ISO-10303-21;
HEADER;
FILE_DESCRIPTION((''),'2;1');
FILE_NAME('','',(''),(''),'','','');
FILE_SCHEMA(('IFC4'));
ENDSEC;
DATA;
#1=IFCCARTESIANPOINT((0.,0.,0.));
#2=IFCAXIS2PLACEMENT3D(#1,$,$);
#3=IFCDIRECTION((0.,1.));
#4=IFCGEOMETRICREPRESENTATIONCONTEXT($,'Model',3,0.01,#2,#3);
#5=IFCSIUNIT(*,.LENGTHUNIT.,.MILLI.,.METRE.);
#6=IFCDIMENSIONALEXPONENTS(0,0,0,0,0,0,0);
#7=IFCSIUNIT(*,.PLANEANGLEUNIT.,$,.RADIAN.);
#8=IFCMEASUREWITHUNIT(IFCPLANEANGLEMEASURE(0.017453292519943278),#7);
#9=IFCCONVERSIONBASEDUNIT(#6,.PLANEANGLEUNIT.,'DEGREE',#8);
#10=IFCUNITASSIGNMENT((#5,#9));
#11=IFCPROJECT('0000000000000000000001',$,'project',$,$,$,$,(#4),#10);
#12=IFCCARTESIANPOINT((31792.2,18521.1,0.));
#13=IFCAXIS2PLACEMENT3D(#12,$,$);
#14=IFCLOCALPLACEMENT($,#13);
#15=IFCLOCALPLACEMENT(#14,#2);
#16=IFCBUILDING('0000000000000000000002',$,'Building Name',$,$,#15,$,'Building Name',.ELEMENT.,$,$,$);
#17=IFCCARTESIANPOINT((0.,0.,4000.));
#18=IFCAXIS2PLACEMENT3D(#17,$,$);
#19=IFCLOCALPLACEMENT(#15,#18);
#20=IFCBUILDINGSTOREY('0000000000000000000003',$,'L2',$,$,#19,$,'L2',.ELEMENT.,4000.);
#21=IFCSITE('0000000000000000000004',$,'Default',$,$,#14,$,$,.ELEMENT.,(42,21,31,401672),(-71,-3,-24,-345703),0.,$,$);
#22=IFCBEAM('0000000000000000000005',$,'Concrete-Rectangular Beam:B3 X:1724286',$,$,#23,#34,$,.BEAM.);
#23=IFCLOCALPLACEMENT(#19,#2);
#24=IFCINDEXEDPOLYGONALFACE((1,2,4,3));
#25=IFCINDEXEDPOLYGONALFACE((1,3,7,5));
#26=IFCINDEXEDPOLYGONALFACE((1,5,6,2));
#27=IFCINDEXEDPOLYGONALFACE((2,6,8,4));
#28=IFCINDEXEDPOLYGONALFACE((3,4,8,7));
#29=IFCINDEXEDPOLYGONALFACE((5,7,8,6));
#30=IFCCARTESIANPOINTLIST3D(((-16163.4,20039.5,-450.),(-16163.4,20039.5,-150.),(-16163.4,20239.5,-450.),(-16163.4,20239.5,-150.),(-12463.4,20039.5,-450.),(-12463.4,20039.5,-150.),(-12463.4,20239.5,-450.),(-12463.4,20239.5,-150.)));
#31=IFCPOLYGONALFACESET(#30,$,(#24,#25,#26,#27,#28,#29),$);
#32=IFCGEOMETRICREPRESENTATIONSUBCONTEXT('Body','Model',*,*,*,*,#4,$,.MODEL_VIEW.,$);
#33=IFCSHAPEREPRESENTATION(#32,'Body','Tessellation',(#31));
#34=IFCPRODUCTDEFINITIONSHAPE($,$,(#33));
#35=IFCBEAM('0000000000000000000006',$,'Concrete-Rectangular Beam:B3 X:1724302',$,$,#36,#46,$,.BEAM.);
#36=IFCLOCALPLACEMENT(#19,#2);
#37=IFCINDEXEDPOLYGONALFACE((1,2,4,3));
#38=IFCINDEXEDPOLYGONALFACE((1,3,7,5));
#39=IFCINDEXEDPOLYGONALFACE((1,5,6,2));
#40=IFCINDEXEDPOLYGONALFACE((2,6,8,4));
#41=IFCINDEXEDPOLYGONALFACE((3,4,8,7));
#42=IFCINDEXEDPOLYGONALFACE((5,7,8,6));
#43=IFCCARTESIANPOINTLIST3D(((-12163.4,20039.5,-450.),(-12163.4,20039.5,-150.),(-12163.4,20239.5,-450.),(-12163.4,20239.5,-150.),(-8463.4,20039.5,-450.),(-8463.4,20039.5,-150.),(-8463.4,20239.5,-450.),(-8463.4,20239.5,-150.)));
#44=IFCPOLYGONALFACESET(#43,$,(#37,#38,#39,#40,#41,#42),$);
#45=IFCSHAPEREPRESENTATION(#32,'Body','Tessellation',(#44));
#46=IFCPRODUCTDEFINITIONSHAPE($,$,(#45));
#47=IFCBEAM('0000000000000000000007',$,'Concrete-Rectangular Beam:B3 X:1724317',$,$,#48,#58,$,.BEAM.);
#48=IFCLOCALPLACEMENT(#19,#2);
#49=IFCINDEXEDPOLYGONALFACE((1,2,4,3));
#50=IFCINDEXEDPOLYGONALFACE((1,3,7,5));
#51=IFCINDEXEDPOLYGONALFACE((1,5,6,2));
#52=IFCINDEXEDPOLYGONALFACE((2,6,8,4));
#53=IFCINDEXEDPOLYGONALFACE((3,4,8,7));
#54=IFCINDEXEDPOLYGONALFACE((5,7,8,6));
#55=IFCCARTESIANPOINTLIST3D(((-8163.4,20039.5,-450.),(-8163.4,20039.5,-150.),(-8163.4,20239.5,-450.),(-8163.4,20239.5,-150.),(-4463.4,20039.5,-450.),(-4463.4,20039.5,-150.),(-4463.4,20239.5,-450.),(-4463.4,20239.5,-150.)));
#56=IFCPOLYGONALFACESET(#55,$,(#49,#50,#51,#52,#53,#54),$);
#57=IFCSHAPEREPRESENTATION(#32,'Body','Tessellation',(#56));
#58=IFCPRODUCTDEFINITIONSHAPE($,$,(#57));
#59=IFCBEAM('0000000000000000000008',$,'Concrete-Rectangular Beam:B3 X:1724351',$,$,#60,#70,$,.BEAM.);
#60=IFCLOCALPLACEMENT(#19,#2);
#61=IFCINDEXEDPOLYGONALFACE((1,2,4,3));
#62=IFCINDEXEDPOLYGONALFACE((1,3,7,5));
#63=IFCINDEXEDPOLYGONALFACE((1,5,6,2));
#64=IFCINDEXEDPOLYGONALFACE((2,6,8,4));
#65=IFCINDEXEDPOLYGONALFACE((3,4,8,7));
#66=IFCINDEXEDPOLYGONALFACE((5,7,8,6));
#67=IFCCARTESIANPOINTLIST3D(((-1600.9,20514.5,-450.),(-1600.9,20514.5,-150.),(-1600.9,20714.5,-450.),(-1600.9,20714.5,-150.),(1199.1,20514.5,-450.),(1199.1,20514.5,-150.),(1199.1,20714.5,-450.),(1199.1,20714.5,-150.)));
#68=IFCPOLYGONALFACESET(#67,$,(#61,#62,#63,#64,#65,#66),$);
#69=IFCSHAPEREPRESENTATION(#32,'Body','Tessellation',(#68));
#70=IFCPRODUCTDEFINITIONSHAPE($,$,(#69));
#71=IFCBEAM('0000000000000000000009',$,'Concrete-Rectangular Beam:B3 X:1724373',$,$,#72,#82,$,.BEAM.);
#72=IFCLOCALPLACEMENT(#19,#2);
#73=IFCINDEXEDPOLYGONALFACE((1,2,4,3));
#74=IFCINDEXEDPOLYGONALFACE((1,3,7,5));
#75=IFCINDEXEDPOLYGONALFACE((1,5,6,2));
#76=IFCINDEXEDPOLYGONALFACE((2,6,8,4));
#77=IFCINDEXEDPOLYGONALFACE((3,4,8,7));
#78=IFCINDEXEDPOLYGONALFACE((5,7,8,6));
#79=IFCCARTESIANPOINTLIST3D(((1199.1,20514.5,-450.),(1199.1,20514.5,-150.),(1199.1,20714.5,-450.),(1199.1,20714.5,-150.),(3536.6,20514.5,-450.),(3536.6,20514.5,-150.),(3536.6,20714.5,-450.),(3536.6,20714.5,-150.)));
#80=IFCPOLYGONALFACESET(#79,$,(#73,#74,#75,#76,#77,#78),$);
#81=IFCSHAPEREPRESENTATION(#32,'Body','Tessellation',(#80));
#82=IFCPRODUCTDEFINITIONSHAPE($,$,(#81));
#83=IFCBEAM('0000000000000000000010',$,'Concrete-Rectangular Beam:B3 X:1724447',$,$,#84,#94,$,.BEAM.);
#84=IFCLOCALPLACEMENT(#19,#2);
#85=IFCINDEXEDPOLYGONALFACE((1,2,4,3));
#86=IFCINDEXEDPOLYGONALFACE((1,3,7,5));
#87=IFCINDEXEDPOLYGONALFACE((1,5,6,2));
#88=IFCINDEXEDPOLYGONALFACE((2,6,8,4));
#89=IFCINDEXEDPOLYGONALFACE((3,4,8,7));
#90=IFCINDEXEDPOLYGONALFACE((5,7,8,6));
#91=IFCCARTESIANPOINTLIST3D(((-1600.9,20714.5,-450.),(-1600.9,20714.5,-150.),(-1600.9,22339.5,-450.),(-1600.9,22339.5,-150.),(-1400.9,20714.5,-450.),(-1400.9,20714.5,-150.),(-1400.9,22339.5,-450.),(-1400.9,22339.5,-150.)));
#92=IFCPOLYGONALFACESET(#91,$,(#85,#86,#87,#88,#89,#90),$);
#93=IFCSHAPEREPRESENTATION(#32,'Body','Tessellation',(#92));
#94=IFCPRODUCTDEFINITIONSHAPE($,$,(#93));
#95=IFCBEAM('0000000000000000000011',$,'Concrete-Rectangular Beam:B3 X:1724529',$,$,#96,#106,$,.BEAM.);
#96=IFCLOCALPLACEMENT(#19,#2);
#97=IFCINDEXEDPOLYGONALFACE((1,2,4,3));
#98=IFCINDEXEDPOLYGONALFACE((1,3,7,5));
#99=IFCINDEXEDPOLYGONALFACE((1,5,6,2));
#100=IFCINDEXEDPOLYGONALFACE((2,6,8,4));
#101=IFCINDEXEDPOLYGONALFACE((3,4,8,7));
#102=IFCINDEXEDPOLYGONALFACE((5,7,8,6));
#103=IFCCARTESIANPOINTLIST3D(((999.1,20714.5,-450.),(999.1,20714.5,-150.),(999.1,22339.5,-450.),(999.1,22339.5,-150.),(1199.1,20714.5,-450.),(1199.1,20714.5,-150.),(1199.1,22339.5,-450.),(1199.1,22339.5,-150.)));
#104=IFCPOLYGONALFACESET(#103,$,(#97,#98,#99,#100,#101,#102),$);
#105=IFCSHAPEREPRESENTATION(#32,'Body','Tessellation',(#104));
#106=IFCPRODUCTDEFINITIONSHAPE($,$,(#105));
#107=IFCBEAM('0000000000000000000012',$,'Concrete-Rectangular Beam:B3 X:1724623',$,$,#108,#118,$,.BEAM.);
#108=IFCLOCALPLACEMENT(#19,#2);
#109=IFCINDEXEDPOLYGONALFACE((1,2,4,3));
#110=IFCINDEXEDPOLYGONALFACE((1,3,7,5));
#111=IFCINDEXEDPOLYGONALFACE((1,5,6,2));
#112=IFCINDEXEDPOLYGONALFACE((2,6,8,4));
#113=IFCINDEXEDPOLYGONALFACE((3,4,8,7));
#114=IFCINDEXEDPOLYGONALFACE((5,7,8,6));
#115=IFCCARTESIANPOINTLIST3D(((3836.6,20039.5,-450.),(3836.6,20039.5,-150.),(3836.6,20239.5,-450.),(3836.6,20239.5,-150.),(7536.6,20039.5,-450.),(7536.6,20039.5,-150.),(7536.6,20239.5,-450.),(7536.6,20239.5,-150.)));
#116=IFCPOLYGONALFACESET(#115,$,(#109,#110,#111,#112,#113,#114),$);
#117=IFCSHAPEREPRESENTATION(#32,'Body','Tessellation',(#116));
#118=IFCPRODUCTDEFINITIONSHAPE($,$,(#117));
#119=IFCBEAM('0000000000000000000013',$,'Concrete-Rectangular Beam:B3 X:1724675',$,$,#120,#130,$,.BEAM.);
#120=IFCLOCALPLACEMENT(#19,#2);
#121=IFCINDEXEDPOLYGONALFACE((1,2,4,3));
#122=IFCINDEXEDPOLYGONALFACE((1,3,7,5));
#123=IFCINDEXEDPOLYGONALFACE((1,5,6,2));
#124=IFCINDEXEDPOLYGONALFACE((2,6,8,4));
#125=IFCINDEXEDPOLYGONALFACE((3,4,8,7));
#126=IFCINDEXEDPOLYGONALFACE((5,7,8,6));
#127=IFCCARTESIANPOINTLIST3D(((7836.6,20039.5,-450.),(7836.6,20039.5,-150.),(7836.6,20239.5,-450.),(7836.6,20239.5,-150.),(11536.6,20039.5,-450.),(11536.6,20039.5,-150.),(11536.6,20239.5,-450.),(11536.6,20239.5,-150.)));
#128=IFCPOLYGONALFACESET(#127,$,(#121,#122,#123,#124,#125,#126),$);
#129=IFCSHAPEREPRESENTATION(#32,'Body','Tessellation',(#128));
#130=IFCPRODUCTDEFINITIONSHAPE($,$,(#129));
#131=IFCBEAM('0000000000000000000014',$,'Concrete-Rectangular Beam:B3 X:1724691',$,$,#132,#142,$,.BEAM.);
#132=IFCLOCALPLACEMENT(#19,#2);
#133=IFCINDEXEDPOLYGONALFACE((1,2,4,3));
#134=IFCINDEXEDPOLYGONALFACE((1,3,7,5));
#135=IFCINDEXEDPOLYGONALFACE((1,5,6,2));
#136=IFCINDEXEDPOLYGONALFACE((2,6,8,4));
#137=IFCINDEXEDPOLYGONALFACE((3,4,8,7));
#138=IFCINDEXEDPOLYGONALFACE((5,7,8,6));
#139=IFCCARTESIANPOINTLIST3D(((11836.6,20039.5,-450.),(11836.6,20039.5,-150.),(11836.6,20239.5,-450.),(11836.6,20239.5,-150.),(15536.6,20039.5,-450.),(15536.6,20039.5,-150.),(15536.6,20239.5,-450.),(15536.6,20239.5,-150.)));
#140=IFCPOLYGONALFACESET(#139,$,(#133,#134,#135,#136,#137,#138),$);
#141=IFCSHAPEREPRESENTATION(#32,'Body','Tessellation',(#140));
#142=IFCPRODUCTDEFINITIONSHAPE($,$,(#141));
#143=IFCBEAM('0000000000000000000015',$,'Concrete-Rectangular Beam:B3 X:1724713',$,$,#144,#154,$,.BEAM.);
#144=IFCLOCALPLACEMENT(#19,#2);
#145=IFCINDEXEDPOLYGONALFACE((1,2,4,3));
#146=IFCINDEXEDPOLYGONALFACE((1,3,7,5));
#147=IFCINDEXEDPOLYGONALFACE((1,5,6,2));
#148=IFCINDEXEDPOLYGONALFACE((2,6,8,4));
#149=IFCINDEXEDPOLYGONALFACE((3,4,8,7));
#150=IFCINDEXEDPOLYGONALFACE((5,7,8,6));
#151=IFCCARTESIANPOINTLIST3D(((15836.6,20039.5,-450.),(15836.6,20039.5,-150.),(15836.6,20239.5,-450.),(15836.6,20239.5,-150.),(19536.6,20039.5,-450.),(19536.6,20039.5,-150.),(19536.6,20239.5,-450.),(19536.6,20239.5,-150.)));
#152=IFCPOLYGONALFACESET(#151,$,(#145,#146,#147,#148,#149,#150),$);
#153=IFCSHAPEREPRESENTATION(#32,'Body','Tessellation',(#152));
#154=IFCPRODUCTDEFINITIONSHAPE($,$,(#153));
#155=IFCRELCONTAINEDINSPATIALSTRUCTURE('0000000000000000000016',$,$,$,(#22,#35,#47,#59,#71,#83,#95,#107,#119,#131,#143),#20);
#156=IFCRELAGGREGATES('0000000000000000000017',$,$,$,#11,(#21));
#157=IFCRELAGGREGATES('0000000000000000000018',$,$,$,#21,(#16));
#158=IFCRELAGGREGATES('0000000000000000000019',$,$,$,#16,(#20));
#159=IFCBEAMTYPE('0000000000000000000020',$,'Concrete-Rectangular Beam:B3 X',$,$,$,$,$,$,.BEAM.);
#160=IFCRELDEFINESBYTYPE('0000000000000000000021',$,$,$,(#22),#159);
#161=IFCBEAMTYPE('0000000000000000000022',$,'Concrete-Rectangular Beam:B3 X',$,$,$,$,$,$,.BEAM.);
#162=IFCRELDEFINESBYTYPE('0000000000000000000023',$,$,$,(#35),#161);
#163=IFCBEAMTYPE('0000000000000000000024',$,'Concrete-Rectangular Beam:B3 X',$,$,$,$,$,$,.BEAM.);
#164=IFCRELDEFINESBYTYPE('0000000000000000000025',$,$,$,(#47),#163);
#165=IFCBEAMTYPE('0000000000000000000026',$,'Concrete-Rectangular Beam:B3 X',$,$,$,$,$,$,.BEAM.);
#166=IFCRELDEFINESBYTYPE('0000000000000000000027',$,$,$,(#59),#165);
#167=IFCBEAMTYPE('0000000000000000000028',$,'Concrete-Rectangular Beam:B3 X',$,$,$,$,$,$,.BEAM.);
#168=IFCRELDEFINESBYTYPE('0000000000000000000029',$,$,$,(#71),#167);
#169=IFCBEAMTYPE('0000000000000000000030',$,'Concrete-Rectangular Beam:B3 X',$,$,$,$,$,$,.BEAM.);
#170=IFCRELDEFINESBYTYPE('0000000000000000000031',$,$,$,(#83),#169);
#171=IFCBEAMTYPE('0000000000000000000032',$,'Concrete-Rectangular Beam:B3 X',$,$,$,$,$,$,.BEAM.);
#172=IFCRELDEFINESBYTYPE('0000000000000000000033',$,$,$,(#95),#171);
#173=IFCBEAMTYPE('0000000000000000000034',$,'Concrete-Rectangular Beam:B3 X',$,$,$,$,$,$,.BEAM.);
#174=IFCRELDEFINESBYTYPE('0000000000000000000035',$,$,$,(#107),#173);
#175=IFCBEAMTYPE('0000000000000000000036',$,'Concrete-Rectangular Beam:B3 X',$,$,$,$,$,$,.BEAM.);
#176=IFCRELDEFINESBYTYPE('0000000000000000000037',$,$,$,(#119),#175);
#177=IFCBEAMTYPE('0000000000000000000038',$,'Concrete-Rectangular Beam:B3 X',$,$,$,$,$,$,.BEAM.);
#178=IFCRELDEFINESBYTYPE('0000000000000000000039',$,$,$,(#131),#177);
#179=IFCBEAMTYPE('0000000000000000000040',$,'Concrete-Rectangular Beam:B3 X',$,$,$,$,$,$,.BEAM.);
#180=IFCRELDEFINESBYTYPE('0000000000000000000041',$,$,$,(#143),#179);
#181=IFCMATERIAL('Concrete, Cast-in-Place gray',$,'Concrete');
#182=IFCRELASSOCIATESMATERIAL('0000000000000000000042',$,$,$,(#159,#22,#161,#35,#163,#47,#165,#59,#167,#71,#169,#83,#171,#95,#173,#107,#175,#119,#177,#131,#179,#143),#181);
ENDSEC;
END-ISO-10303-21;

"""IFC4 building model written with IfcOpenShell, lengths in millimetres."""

from ifc_helpers import new_model, entity, si_unit, converted_unit, direction, frame, origin, place, context, subcontext, project, spatial, indexed_curve, outline, extrude, source, transform, mapped, material, type_object, type_shapes, element, save


model = new_model("IFC4")

# Units and contexts
model_context = context("Model", 3, precision=0.01, world=origin(), true_north=direction((0.0, 1.0)))
body_context = subcontext(model_context, "Body", "Model", "MODEL_VIEW")
ifc_project = project(units=[si_unit("LENGTHUNIT", "METRE", prefix="MILLI"), converted_unit("PLANEANGLEUNIT", "DEGREE", entity("IfcPlaneAngleMeasure", 0.017453292519943278), si_unit("PLANEANGLEUNIT", "RADIAN"), dimensions=[0, 0, 0, 0, 0, 0, 0])], contexts=[model_context])

# Site, building, storey
site_placement = place(None, frame((31792.2, 18521.1, 0.0)))
site = spatial("IfcSite", under=ifc_project, at=site_placement, Name="Default", CompositionType="ELEMENT", RefLatitude=(42, 21, 31, 401672), RefLongitude=(-71, -3, -24, -345703), RefElevation=0.0)
building_placement = place(site_placement, origin())
building = spatial("IfcBuilding", under=site, at=building_placement, Name="Building Name", LongName="Building Name", CompositionType="ELEMENT")
storey_placement = place(building_placement, frame((0.0, 0.0, 4000.0)))
storey = spatial("IfcBuildingStorey", under=building, at=storey_placement, Name="L2", LongName="L2", CompositionType="ELEMENT", Elevation=4000.0)

# Beams
ifc_material = material(Name="Concrete, Cast-in-Place gray", Category="Concrete")
beam_type_1 = type_object("IfcBeamType", Name="Concrete-Rectangular Beam:B3 X", PredefinedType="BEAM", material=ifc_material)
shared_shape_1 = source(origin(), body_context, "Body", "SweptSolid", [
    extrude(outline(indexed_curve([(-150.0, -100.0), (150.0, -100.0), (150.0, 100.0), (-150.0, 100.0), (-150.0, -100.0)], self_intersect=False)), frame((-16163.4, 20139.5, 3700.0), z_axis=(1.0, 0.0, 0.0), x_axis=(0.0, 0.0, -1.0)), (0.0, 0.0, 1.0), 3700.0),
])
type_shapes(beam_type_1, [shared_shape_1])
beam_1_placement = place(storey_placement, frame((0.0, 0.0, -4000.0)))
element("IfcBeam", 1, at=beam_1_placement, inside=storey, type_object=beam_type_1, material=ifc_material, Name="Concrete-Rectangular Beam:B3 X:1724286", PredefinedType="BEAM", context=body_context, shape_type="MappedRepresentation", body=[
    mapped(shared_shape_1, transform((0.0, 0.0, 0.0), scale=1.0)),
])
beam_type_2 = type_object("IfcBeamType", Name="Concrete-Rectangular Beam:B3 X", PredefinedType="BEAM", material=ifc_material)
shared_shape_2 = source(origin(), body_context, "Body", "SweptSolid", [
    extrude(outline(indexed_curve([(-150.0, -100.0), (150.0, -100.0), (150.0, 100.0), (-150.0, 100.0), (-150.0, -100.0)], self_intersect=False)), frame((-12163.4, 20139.5, 3700.0), z_axis=(1.0, 0.0, 0.0), x_axis=(0.0, 0.0, -1.0)), (0.0, 0.0, 1.0), 3700.0),
])
type_shapes(beam_type_2, [shared_shape_2])
beam_2_placement = place(storey_placement, frame((0.0, 0.0, -4000.0)))
element("IfcBeam", 2, at=beam_2_placement, inside=storey, type_object=beam_type_2, material=ifc_material, Name="Concrete-Rectangular Beam:B3 X:1724302", PredefinedType="BEAM", context=body_context, shape_type="MappedRepresentation", body=[
    mapped(shared_shape_2, transform((0.0, 0.0, 0.0), scale=1.0)),
])
beam_type_3 = type_object("IfcBeamType", Name="Concrete-Rectangular Beam:B3 X", PredefinedType="BEAM", material=ifc_material)
shared_shape_3 = source(origin(), body_context, "Body", "SweptSolid", [
    extrude(outline(indexed_curve([(-150.0, -100.0), (150.0, -100.0), (150.0, 100.0), (-150.0, 100.0), (-150.0, -100.0)], self_intersect=False)), frame((-8163.4, 20139.5, 3700.0), z_axis=(1.0, 0.0, 0.0), x_axis=(0.0, 0.0, -1.0)), (0.0, 0.0, 1.0), 3700.0),
])
type_shapes(beam_type_3, [shared_shape_3])
beam_3_placement = place(storey_placement, frame((0.0, 0.0, -4000.0)))
element("IfcBeam", 3, at=beam_3_placement, inside=storey, type_object=beam_type_3, material=ifc_material, Name="Concrete-Rectangular Beam:B3 X:1724317", PredefinedType="BEAM", context=body_context, shape_type="MappedRepresentation", body=[
    mapped(shared_shape_3, transform((0.0, 0.0, 0.0), scale=1.0)),
])
beam_type_4 = type_object("IfcBeamType", Name="Concrete-Rectangular Beam:B3 X", PredefinedType="BEAM", material=ifc_material)
shared_shape_4 = source(origin(), body_context, "Body", "SweptSolid", [
    extrude(outline(indexed_curve([(-150.0, -100.0), (150.0, -100.0), (150.0, 100.0), (-150.0, 100.0), (-150.0, -100.0)], self_intersect=False)), frame((-1600.9, 20614.5, 3700.0), z_axis=(1.0, 0.0, 0.0), x_axis=(0.0, 0.0, -1.0)), (0.0, 0.0, 1.0), 2800.0),
])
type_shapes(beam_type_4, [shared_shape_4])
beam_4_placement = place(storey_placement, frame((0.0, 0.0, -4000.0)))
element("IfcBeam", 4, at=beam_4_placement, inside=storey, type_object=beam_type_4, material=ifc_material, Name="Concrete-Rectangular Beam:B3 X:1724351", PredefinedType="BEAM", context=body_context, shape_type="MappedRepresentation", body=[
    mapped(shared_shape_4, transform((0.0, 0.0, 0.0), scale=1.0)),
])
beam_type_5 = type_object("IfcBeamType", Name="Concrete-Rectangular Beam:B3 X", PredefinedType="BEAM", material=ifc_material)
shared_shape_5 = source(origin(), body_context, "Body", "SweptSolid", [
    extrude(outline(indexed_curve([(-150.0, -100.0), (150.0, -100.0), (150.0, 100.0), (-150.0, 100.0), (-150.0, -100.0)], self_intersect=False)), frame((1199.1, 20614.5, 3700.0), z_axis=(1.0, 0.0, 0.0), x_axis=(0.0, 0.0, -1.0)), (0.0, 0.0, 1.0), 2337.5),
])
type_shapes(beam_type_5, [shared_shape_5])
beam_5_placement = place(storey_placement, frame((0.0, 0.0, -4000.0)))
element("IfcBeam", 5, at=beam_5_placement, inside=storey, type_object=beam_type_5, material=ifc_material, Name="Concrete-Rectangular Beam:B3 X:1724373", PredefinedType="BEAM", context=body_context, shape_type="MappedRepresentation", body=[
    mapped(shared_shape_5, transform((0.0, 0.0, 0.0), scale=1.0)),
])
beam_type_6 = type_object("IfcBeamType", Name="Concrete-Rectangular Beam:B3 X", PredefinedType="BEAM", material=ifc_material)
shared_shape_6 = source(origin(), body_context, "Body", "SweptSolid", [
    extrude(outline(indexed_curve([(-100.0, -150.0), (100.0, -150.0), (100.0, 150.0), (-100.0, 150.0), (-100.0, -150.0)], self_intersect=False)), frame((-1500.9, 20714.5, 3700.0), z_axis=(0.0, 1.0, 0.0), x_axis=(-1.0, 0.0, 0.0)), (0.0, 0.0, 1.0), 1625.0),
])
type_shapes(beam_type_6, [shared_shape_6])
beam_6_placement = place(storey_placement, frame((0.0, 0.0, -4000.0)))
element("IfcBeam", 6, at=beam_6_placement, inside=storey, type_object=beam_type_6, material=ifc_material, Name="Concrete-Rectangular Beam:B3 X:1724447", PredefinedType="BEAM", context=body_context, shape_type="MappedRepresentation", body=[
    mapped(shared_shape_6, transform((0.0, 0.0, 0.0), scale=1.0)),
])
beam_type_7 = type_object("IfcBeamType", Name="Concrete-Rectangular Beam:B3 X", PredefinedType="BEAM", material=ifc_material)
shared_shape_7 = source(origin(), body_context, "Body", "SweptSolid", [
    extrude(outline(indexed_curve([(-100.0, -150.0), (100.0, -150.0), (100.0, 150.0), (-100.0, 150.0), (-100.0, -150.0)], self_intersect=False)), frame((1099.1, 22339.5, 3700.0), z_axis=(0.0, -1.0, 0.0), x_axis=(-1.0, 0.0, 0.0)), (0.0, 0.0, 1.0), 1625.0),
])
type_shapes(beam_type_7, [shared_shape_7])
beam_7_placement = place(storey_placement, frame((0.0, 0.0, -4000.0)))
element("IfcBeam", 7, at=beam_7_placement, inside=storey, type_object=beam_type_7, material=ifc_material, Name="Concrete-Rectangular Beam:B3 X:1724529", PredefinedType="BEAM", context=body_context, shape_type="MappedRepresentation", body=[
    mapped(shared_shape_7, transform((0.0, 0.0, 0.0), scale=1.0)),
])
beam_type_8 = type_object("IfcBeamType", Name="Concrete-Rectangular Beam:B3 X", PredefinedType="BEAM", material=ifc_material)
shared_shape_8 = source(origin(), body_context, "Body", "SweptSolid", [
    extrude(outline(indexed_curve([(-150.0, -100.0), (150.0, -100.0), (150.0, 100.0), (-150.0, 100.0), (-150.0, -100.0)], self_intersect=False)), frame((3836.6, 20139.5, 3700.0), z_axis=(1.0, 0.0, 0.0), x_axis=(0.0, 0.0, -1.0)), (0.0, 0.0, 1.0), 3700.0),
])
type_shapes(beam_type_8, [shared_shape_8])
beam_8_placement = place(storey_placement, frame((0.0, 0.0, -4000.0)))
element("IfcBeam", 8, at=beam_8_placement, inside=storey, type_object=beam_type_8, material=ifc_material, Name="Concrete-Rectangular Beam:B3 X:1724623", PredefinedType="BEAM", context=body_context, shape_type="MappedRepresentation", body=[
    mapped(shared_shape_8, transform((0.0, 0.0, 0.0), scale=1.0)),
])
beam_type_9 = type_object("IfcBeamType", Name="Concrete-Rectangular Beam:B3 X", PredefinedType="BEAM", material=ifc_material)
shared_shape_9 = source(origin(), body_context, "Body", "SweptSolid", [
    extrude(outline(indexed_curve([(-150.0, -100.0), (150.0, -100.0), (150.0, 100.0), (-150.0, 100.0), (-150.0, -100.0)], self_intersect=False)), frame((7836.6, 20139.5, 3700.0), z_axis=(1.0, 0.0, 0.0), x_axis=(0.0, 0.0, -1.0)), (0.0, 0.0, 1.0), 3700.0),
])
type_shapes(beam_type_9, [shared_shape_9])
beam_9_placement = place(storey_placement, frame((0.0, 0.0, -4000.0)))
element("IfcBeam", 9, at=beam_9_placement, inside=storey, type_object=beam_type_9, material=ifc_material, Name="Concrete-Rectangular Beam:B3 X:1724675", PredefinedType="BEAM", context=body_context, shape_type="MappedRepresentation", body=[
    mapped(shared_shape_9, transform((0.0, 0.0, 0.0), scale=1.0)),
])
beam_type_10 = type_object("IfcBeamType", Name="Concrete-Rectangular Beam:B3 X", PredefinedType="BEAM", material=ifc_material)
shared_shape_10 = source(origin(), body_context, "Body", "SweptSolid", [
    extrude(outline(indexed_curve([(-150.0, -100.0), (150.0, -100.0), (150.0, 100.0), (-150.0, 100.0), (-150.0, -100.0)], self_intersect=False)), frame((11836.6, 20139.5, 3700.0), z_axis=(1.0, 0.0, 0.0), x_axis=(0.0, 0.0, -1.0)), (0.0, 0.0, 1.0), 3700.0),
])
type_shapes(beam_type_10, [shared_shape_10])
beam_10_placement = place(storey_placement, frame((0.0, 0.0, -4000.0)))
element("IfcBeam", 10, at=beam_10_placement, inside=storey, type_object=beam_type_10, material=ifc_material, Name="Concrete-Rectangular Beam:B3 X:1724691", PredefinedType="BEAM", context=body_context, shape_type="MappedRepresentation", body=[
    mapped(shared_shape_10, transform((0.0, 0.0, 0.0), scale=1.0)),
])
beam_type_11 = type_object("IfcBeamType", Name="Concrete-Rectangular Beam:B3 X", PredefinedType="BEAM", material=ifc_material)
shared_shape_11 = source(origin(), body_context, "Body", "SweptSolid", [
    extrude(outline(indexed_curve([(-150.0, -100.0), (150.0, -100.0), (150.0, 100.0), (-150.0, 100.0), (-150.0, -100.0)], self_intersect=False)), frame((15836.6, 20139.5, 3700.0), z_axis=(1.0, 0.0, 0.0), x_axis=(0.0, 0.0, -1.0)), (0.0, 0.0, 1.0), 3700.0),
])
type_shapes(beam_type_11, [shared_shape_11])
beam_11_placement = place(storey_placement, frame((0.0, 0.0, -4000.0)))
element("IfcBeam", 11, at=beam_11_placement, inside=storey, type_object=beam_type_11, material=ifc_material, Name="Concrete-Rectangular Beam:B3 X:1724713", PredefinedType="BEAM", context=body_context, shape_type="MappedRepresentation", body=[
    mapped(shared_shape_11, transform((0.0, 0.0, 0.0), scale=1.0)),
])

save(model, "model.ifc")
